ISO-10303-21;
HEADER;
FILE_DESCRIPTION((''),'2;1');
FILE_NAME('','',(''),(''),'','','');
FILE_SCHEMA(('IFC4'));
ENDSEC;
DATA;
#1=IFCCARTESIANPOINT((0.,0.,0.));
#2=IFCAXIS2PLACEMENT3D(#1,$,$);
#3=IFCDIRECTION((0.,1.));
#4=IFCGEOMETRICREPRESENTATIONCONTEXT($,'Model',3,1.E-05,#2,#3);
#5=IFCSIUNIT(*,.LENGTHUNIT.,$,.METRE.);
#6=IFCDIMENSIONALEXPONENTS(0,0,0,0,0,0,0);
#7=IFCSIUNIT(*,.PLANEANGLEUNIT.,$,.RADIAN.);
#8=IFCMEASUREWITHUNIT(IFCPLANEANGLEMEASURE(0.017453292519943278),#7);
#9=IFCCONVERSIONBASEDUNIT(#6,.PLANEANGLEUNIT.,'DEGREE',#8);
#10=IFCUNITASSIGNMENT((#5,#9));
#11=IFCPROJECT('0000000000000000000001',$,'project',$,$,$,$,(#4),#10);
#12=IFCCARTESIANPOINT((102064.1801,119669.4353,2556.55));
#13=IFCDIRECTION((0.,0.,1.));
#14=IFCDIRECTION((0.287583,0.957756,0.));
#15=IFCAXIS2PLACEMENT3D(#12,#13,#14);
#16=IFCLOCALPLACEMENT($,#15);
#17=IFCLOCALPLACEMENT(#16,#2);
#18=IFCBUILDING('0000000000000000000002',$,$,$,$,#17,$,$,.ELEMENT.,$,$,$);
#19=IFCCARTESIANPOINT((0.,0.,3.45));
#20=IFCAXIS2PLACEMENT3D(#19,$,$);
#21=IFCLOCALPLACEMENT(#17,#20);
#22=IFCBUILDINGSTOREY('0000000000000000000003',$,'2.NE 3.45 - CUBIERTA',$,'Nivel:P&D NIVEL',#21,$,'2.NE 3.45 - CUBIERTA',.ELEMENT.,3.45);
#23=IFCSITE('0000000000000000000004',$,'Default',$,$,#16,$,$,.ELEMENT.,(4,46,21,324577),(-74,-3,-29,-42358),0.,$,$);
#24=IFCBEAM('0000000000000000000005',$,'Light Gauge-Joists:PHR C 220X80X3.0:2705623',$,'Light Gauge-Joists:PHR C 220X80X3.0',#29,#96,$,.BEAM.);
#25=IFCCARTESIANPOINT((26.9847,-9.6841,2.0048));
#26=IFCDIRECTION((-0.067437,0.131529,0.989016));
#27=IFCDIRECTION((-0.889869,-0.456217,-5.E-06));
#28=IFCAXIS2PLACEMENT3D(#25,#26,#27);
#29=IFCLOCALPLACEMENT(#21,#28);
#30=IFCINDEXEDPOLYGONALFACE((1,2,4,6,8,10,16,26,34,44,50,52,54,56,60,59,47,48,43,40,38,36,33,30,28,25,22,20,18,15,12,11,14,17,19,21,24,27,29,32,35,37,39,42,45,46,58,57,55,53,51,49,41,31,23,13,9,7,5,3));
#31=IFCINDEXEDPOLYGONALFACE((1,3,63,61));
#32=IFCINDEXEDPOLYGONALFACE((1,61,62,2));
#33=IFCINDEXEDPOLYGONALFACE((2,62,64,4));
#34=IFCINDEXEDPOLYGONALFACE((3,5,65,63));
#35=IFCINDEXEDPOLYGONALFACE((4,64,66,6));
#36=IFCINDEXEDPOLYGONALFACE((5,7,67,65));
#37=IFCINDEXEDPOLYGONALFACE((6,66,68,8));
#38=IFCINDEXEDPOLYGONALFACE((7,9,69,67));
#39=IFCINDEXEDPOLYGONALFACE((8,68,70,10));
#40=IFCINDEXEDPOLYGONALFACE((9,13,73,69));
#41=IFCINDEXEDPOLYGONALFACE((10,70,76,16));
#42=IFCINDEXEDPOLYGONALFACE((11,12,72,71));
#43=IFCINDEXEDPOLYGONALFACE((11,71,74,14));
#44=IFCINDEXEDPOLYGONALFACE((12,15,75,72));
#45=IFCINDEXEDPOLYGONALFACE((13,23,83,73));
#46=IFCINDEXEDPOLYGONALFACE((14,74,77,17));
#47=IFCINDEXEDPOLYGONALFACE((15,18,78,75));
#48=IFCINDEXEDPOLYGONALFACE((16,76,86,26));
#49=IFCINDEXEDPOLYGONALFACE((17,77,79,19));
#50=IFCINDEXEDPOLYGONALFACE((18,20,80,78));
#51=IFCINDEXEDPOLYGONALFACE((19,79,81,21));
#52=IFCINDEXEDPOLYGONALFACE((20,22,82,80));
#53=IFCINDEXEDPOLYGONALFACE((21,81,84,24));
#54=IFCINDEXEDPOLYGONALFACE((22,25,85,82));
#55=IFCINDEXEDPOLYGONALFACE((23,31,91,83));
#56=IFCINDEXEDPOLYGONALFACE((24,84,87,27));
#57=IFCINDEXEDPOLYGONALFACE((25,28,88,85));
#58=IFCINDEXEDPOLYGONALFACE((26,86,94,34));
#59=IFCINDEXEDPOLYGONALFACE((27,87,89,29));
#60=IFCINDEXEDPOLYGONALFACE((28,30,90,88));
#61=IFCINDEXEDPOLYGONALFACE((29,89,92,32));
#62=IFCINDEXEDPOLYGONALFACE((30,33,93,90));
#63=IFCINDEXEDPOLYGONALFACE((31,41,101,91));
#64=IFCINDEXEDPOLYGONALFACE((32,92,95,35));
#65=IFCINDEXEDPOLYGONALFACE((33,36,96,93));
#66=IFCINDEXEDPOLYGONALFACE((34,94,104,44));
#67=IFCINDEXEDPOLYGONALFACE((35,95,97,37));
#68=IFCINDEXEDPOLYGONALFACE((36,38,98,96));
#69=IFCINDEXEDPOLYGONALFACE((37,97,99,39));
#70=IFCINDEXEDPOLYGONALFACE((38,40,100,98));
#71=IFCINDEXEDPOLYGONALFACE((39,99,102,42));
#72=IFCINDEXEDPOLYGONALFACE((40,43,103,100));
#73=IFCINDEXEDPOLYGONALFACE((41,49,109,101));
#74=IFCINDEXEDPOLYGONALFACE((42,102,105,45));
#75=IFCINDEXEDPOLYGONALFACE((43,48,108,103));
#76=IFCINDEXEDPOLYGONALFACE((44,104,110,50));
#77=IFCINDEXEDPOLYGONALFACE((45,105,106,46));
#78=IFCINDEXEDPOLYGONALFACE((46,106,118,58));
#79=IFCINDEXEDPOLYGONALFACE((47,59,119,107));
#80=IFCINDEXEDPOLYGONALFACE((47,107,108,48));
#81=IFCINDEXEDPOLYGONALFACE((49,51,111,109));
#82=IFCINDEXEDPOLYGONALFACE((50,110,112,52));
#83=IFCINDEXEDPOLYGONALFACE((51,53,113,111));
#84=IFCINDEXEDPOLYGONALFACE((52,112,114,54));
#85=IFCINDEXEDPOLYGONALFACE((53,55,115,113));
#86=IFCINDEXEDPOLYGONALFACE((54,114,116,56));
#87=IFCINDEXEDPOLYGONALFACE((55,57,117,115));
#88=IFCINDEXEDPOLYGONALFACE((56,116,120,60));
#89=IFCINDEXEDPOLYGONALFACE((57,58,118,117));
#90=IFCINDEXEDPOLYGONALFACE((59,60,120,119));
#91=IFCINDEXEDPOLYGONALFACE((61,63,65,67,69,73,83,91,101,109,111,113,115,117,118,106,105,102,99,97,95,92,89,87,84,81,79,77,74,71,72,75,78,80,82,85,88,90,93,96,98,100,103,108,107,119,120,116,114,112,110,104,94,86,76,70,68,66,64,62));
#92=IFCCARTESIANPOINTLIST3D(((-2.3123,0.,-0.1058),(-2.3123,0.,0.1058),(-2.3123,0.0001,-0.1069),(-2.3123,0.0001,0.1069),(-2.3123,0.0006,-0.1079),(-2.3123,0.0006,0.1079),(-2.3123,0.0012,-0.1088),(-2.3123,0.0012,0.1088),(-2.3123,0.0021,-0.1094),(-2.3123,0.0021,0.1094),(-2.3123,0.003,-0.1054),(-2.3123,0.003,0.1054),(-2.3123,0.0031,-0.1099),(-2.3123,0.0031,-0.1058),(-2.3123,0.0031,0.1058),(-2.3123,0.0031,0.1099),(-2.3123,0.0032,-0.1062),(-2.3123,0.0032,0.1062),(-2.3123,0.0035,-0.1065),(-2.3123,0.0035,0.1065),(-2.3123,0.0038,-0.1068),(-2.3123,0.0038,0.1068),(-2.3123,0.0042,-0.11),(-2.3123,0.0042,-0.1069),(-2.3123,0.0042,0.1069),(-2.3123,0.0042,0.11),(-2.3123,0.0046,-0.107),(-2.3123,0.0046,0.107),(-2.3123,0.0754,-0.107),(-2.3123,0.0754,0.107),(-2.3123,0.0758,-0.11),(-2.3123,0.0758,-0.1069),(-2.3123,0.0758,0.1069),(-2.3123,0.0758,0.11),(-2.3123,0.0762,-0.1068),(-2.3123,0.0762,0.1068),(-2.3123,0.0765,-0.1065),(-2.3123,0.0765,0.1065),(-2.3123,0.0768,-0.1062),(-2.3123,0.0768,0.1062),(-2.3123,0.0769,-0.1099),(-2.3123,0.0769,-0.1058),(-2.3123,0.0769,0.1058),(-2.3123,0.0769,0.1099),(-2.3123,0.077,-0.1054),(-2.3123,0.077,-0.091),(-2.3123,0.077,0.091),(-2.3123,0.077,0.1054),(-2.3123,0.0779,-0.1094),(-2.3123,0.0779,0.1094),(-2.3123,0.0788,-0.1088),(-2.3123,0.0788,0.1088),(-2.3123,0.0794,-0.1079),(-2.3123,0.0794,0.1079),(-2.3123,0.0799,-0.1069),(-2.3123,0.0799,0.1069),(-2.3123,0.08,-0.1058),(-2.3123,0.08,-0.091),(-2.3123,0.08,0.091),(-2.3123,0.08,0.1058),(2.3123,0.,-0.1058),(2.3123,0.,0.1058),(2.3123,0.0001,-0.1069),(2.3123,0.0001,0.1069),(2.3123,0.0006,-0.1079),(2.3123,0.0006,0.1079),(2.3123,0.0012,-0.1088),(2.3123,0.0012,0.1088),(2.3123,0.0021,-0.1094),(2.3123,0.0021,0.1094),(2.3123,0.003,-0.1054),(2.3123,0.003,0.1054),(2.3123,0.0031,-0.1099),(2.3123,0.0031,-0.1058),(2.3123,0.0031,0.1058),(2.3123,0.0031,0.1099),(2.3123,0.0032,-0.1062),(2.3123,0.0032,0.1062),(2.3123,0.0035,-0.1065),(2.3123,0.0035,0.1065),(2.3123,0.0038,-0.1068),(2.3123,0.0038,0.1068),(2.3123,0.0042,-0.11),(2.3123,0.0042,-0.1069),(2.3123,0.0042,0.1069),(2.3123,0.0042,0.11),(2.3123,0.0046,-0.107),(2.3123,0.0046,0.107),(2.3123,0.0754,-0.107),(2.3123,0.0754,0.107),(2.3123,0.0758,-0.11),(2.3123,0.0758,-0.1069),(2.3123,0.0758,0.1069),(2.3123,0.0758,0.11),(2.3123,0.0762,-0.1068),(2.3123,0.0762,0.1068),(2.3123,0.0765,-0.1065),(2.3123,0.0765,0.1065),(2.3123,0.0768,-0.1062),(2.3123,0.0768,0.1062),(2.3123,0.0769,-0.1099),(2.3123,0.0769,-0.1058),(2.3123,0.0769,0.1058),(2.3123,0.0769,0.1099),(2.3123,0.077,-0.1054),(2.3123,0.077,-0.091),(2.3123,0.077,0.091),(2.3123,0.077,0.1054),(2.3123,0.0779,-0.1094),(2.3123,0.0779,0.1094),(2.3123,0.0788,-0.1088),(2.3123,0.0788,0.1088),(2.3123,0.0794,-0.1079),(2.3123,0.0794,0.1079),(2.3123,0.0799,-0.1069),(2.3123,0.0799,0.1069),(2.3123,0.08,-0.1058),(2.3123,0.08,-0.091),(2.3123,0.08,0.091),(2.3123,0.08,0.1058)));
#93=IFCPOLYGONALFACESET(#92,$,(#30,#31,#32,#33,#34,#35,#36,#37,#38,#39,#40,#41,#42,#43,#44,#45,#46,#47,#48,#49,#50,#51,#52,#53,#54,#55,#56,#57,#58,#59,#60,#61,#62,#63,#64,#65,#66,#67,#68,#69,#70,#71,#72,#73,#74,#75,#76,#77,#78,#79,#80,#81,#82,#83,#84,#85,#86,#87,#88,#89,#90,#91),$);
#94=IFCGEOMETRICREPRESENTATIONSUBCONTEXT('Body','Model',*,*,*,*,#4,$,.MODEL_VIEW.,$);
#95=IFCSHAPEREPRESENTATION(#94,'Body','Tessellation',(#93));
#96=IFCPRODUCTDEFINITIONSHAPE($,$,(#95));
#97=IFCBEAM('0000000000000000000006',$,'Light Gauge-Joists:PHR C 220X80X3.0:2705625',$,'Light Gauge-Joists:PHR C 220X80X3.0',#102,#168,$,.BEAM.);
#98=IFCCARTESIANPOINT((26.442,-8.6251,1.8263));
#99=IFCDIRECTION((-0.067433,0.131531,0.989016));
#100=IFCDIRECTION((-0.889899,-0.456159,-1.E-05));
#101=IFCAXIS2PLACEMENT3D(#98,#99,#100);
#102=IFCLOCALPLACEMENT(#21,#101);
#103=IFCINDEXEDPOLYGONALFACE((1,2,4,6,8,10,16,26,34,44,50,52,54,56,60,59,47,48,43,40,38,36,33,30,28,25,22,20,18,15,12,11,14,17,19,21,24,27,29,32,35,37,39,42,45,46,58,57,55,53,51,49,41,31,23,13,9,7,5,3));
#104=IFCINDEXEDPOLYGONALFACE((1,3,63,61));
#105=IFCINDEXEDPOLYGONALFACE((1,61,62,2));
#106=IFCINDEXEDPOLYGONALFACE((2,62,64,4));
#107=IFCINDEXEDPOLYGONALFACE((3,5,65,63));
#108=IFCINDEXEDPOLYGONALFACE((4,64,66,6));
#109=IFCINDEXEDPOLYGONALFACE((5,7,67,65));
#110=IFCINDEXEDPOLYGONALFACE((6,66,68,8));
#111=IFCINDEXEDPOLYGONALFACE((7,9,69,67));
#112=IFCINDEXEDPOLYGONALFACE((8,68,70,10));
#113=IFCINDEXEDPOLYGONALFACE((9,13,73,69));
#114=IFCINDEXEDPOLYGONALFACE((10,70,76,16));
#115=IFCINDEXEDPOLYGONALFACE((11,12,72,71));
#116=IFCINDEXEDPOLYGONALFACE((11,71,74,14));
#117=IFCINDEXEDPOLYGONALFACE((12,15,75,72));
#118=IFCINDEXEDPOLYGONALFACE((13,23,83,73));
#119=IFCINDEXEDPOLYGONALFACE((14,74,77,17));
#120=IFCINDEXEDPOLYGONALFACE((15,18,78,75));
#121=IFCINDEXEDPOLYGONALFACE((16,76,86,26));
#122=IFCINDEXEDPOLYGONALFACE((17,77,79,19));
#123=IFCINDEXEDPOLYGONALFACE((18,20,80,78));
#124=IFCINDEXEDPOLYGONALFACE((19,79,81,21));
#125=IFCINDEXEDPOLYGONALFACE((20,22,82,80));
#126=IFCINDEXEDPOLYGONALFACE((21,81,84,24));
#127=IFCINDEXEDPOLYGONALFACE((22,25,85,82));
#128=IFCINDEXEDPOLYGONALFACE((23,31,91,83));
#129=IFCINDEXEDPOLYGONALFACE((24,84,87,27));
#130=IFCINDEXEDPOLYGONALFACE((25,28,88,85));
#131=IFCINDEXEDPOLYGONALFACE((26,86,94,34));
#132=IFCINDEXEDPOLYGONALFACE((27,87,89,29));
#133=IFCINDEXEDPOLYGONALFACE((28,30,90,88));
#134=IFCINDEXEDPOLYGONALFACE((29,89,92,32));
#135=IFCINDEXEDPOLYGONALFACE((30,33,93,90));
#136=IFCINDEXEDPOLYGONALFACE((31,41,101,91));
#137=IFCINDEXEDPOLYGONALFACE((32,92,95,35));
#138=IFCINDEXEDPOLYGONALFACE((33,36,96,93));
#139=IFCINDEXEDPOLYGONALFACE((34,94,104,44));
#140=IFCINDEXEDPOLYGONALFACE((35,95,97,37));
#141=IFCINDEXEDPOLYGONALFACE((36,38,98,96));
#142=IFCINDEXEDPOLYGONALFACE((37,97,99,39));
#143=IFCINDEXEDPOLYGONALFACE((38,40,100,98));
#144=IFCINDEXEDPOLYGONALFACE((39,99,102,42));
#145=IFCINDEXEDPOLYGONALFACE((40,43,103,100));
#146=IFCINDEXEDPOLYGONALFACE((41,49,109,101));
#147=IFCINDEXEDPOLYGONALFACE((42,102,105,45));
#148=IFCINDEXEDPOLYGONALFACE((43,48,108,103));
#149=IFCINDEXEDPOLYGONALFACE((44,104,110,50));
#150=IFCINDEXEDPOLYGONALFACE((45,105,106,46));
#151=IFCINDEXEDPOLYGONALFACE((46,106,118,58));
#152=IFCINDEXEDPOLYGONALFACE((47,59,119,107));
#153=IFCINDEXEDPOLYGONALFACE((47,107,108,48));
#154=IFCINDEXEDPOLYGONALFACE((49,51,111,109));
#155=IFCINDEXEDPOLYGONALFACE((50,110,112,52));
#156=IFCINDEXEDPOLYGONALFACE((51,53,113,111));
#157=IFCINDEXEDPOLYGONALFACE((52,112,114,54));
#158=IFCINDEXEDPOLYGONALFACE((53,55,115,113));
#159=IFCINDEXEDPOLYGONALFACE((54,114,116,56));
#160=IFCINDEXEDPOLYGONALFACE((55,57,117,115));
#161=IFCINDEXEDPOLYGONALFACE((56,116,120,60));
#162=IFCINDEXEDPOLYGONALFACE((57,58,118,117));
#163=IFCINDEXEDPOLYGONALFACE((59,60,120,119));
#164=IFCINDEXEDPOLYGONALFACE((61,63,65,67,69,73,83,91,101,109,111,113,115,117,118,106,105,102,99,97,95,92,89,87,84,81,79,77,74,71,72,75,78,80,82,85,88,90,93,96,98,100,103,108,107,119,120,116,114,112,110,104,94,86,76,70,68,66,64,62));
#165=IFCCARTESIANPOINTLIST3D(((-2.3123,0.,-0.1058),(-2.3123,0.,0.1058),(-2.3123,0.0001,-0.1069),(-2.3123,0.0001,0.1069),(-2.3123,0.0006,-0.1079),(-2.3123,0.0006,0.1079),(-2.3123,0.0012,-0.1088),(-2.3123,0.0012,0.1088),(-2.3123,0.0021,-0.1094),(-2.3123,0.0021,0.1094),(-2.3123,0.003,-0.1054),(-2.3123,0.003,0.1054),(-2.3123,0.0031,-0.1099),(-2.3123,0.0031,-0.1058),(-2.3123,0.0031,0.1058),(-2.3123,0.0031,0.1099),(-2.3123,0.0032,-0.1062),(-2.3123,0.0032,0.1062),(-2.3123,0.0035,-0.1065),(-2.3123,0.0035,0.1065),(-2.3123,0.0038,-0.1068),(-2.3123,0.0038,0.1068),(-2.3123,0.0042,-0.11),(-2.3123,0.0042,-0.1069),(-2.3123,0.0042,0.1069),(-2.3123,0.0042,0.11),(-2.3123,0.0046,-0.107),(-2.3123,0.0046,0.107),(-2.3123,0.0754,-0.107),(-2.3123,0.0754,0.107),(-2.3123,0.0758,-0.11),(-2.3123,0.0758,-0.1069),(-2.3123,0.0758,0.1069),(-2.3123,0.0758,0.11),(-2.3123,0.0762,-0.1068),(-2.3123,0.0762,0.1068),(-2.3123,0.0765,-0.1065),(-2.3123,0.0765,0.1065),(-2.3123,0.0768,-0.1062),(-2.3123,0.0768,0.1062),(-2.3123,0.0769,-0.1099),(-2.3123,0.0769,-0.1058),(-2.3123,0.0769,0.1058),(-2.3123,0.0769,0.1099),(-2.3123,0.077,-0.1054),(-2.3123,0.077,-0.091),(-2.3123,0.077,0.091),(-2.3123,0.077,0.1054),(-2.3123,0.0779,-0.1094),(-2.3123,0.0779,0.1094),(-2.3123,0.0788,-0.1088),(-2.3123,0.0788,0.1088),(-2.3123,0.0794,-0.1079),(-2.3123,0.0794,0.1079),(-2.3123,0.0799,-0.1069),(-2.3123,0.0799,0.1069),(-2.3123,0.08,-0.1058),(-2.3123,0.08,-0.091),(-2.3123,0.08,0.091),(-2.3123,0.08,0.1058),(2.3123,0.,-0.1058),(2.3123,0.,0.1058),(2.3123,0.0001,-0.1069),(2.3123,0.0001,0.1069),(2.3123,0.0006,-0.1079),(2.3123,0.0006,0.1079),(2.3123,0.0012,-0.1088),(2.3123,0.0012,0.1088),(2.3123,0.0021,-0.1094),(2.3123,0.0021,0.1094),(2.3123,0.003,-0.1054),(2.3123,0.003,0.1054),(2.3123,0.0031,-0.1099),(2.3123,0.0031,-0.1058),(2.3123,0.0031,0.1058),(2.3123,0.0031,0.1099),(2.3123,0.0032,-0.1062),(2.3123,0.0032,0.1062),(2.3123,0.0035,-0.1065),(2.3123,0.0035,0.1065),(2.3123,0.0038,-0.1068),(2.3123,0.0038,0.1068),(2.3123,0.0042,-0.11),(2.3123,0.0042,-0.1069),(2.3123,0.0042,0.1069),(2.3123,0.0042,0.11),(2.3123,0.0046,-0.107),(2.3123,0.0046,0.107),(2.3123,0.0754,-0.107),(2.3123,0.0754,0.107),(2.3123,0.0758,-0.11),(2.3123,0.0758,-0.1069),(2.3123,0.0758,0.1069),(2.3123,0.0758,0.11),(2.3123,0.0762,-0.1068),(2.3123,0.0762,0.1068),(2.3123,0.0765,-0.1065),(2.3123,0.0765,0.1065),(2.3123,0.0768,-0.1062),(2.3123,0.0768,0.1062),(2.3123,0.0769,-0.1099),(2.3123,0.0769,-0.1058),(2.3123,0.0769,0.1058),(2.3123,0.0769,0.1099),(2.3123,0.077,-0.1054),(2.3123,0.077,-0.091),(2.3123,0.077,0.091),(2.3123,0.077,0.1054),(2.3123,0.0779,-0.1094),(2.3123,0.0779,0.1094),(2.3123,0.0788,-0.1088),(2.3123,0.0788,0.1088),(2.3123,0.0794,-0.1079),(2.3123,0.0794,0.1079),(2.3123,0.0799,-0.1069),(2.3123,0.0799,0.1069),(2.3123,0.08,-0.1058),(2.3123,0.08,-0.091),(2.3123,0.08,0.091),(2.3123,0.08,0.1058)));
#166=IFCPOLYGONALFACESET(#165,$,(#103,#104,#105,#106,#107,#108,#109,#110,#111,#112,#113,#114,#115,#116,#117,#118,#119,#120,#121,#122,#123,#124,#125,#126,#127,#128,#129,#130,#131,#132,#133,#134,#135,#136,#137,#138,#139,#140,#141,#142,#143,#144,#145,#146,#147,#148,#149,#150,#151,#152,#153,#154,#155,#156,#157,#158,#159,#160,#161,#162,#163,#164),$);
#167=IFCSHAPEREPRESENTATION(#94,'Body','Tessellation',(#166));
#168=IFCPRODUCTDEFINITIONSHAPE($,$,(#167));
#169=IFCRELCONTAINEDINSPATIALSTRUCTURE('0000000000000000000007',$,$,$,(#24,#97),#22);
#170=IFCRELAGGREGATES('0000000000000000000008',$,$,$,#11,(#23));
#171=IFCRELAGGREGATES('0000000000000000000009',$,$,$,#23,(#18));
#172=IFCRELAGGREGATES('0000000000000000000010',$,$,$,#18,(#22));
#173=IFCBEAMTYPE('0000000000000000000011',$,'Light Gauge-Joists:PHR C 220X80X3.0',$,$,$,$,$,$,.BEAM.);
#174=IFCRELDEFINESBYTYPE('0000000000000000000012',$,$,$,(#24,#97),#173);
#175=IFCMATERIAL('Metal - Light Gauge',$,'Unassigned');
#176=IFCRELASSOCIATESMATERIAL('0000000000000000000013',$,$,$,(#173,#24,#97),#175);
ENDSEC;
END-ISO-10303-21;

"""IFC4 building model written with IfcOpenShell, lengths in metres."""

from ifc_helpers import new_model, entity, si_unit, converted_unit, direction, frame, origin, place, context, subcontext, project, spatial, line, arc, indexed_curve, outline, extrude, source, transform, mapped, material, type_object, type_shapes, element, save


model = new_model("IFC4")

# Units and contexts
model_context = context("Model", 3, precision=1e-05, world=origin(), true_north=direction((0.0, 1.0)))
body_context = subcontext(model_context, "Body", "Model", "MODEL_VIEW")
ifc_project = project(units=[si_unit("LENGTHUNIT", "METRE"), converted_unit("PLANEANGLEUNIT", "DEGREE", entity("IfcPlaneAngleMeasure", 0.017453292519943278), si_unit("PLANEANGLEUNIT", "RADIAN"), dimensions=[0, 0, 0, 0, 0, 0, 0])], contexts=[model_context])

# Site, building, storey
site_placement = place(None, frame((102064.1801, 119669.4353, 2556.55), z_axis=(0.0, 0.0, 1.0), x_axis=(0.287583, 0.957756, 0.0)))
site = spatial("IfcSite", under=ifc_project, at=site_placement, Name="Default", CompositionType="ELEMENT", RefLatitude=(4, 46, 21, 324577), RefLongitude=(-74, -3, -29, -42358), RefElevation=0.0)
building_placement = place(site_placement, origin())
building = spatial("IfcBuilding", under=site, at=building_placement, CompositionType="ELEMENT")
storey_placement = place(building_placement, frame((0.0, 0.0, 3.45)))
storey = spatial("IfcBuildingStorey", under=building, at=storey_placement, Name="2.NE 3.45 - CUBIERTA", ObjectType="Nivel:P&D NIVEL", LongName="2.NE 3.45 - CUBIERTA", CompositionType="ELEMENT", Elevation=3.45)

# Beams
ifc_material_1 = material(Name="Metal - Light Gauge", Category="Unassigned")
beam_type_1 = type_object("IfcBeamType", Name="Light Gauge-Joists:PHR C 220X80X3.0", PredefinedType="BEAM", material=ifc_material_1)
shared_shape_1 = source(origin(), body_context, "Body", "SweptSolid", [
    extrude(outline(indexed_curve([(-0.0477, -0.1058), (-0.0465, -0.1088), (-0.0435, -0.11), (0.0281, -0.11), (0.0311, -0.1088), (0.0323, -0.1058), (0.0323, -0.091), (0.0293, -0.091), (0.0293, -0.1054), (0.0288, -0.1065), (0.0277, -0.107), (-0.0431, -0.107), (-0.0442, -0.1065), (-0.0447, -0.1054), (-0.0447, 0.1054), (-0.0442, 0.1065), (-0.0431, 0.107), (0.0277, 0.107), (0.0288, 0.1065), (0.0293, 0.1054), (0.0293, 0.091), (0.0323, 0.091), (0.0323, 0.1058), (0.0311, 0.1088), (0.0281, 0.11), (-0.0435, 0.11), (-0.0465, 0.1088), (-0.0477, 0.1058)], segments=[arc(1, 2, 3), line(3, 4), arc(4, 5, 6), line(6, 7, 8, 9), arc(9, 10, 11), line(11, 12), arc(12, 13, 14), line(14, 15), arc(15, 16, 17), line(17, 18), arc(18, 19, 20), line(20, 21, 22, 23), arc(23, 24, 25), line(25, 26), arc(26, 27, 28), line(28, 1)], self_intersect=False)), frame((-2.3123, 0.0477, 0.0), z_axis=(1.0, 0.0, 0.0), x_axis=(0.0, 1.0, 0.0)), (0.0, 0.0, 1.0), 4.6246),
])
type_shapes(beam_type_1, [shared_shape_1])
for number, where, z_axis, x_axis, name in (
    (1, (26.9847, -9.6841, 2.0048), (-0.067437, 0.131529, 0.989016), (-0.889869, -0.456217, -0.000005), "Light Gauge-Joists:PHR C 220X80X3.0:2705623"),
    (2, (26.442, -8.6251, 1.8263), (-0.067433, 0.131531, 0.989016), (-0.889899, -0.456159, -0.00001), "Light Gauge-Joists:PHR C 220X80X3.0:2705625"),
):
    element("IfcBeam", number, at=place(storey_placement, frame(where, z_axis=z_axis, x_axis=x_axis)), inside=storey, type_object=beam_type_1, material=ifc_material_1, Name=name, ObjectType="Light Gauge-Joists:PHR C 220X80X3.0", PredefinedType="BEAM", context=body_context, shape_type="MappedRepresentation", body=[
        mapped(shared_shape_1, transform((0.0, 0.0, 0.0), scale=1.0)),
    ])

save(model, "model.ifc")
